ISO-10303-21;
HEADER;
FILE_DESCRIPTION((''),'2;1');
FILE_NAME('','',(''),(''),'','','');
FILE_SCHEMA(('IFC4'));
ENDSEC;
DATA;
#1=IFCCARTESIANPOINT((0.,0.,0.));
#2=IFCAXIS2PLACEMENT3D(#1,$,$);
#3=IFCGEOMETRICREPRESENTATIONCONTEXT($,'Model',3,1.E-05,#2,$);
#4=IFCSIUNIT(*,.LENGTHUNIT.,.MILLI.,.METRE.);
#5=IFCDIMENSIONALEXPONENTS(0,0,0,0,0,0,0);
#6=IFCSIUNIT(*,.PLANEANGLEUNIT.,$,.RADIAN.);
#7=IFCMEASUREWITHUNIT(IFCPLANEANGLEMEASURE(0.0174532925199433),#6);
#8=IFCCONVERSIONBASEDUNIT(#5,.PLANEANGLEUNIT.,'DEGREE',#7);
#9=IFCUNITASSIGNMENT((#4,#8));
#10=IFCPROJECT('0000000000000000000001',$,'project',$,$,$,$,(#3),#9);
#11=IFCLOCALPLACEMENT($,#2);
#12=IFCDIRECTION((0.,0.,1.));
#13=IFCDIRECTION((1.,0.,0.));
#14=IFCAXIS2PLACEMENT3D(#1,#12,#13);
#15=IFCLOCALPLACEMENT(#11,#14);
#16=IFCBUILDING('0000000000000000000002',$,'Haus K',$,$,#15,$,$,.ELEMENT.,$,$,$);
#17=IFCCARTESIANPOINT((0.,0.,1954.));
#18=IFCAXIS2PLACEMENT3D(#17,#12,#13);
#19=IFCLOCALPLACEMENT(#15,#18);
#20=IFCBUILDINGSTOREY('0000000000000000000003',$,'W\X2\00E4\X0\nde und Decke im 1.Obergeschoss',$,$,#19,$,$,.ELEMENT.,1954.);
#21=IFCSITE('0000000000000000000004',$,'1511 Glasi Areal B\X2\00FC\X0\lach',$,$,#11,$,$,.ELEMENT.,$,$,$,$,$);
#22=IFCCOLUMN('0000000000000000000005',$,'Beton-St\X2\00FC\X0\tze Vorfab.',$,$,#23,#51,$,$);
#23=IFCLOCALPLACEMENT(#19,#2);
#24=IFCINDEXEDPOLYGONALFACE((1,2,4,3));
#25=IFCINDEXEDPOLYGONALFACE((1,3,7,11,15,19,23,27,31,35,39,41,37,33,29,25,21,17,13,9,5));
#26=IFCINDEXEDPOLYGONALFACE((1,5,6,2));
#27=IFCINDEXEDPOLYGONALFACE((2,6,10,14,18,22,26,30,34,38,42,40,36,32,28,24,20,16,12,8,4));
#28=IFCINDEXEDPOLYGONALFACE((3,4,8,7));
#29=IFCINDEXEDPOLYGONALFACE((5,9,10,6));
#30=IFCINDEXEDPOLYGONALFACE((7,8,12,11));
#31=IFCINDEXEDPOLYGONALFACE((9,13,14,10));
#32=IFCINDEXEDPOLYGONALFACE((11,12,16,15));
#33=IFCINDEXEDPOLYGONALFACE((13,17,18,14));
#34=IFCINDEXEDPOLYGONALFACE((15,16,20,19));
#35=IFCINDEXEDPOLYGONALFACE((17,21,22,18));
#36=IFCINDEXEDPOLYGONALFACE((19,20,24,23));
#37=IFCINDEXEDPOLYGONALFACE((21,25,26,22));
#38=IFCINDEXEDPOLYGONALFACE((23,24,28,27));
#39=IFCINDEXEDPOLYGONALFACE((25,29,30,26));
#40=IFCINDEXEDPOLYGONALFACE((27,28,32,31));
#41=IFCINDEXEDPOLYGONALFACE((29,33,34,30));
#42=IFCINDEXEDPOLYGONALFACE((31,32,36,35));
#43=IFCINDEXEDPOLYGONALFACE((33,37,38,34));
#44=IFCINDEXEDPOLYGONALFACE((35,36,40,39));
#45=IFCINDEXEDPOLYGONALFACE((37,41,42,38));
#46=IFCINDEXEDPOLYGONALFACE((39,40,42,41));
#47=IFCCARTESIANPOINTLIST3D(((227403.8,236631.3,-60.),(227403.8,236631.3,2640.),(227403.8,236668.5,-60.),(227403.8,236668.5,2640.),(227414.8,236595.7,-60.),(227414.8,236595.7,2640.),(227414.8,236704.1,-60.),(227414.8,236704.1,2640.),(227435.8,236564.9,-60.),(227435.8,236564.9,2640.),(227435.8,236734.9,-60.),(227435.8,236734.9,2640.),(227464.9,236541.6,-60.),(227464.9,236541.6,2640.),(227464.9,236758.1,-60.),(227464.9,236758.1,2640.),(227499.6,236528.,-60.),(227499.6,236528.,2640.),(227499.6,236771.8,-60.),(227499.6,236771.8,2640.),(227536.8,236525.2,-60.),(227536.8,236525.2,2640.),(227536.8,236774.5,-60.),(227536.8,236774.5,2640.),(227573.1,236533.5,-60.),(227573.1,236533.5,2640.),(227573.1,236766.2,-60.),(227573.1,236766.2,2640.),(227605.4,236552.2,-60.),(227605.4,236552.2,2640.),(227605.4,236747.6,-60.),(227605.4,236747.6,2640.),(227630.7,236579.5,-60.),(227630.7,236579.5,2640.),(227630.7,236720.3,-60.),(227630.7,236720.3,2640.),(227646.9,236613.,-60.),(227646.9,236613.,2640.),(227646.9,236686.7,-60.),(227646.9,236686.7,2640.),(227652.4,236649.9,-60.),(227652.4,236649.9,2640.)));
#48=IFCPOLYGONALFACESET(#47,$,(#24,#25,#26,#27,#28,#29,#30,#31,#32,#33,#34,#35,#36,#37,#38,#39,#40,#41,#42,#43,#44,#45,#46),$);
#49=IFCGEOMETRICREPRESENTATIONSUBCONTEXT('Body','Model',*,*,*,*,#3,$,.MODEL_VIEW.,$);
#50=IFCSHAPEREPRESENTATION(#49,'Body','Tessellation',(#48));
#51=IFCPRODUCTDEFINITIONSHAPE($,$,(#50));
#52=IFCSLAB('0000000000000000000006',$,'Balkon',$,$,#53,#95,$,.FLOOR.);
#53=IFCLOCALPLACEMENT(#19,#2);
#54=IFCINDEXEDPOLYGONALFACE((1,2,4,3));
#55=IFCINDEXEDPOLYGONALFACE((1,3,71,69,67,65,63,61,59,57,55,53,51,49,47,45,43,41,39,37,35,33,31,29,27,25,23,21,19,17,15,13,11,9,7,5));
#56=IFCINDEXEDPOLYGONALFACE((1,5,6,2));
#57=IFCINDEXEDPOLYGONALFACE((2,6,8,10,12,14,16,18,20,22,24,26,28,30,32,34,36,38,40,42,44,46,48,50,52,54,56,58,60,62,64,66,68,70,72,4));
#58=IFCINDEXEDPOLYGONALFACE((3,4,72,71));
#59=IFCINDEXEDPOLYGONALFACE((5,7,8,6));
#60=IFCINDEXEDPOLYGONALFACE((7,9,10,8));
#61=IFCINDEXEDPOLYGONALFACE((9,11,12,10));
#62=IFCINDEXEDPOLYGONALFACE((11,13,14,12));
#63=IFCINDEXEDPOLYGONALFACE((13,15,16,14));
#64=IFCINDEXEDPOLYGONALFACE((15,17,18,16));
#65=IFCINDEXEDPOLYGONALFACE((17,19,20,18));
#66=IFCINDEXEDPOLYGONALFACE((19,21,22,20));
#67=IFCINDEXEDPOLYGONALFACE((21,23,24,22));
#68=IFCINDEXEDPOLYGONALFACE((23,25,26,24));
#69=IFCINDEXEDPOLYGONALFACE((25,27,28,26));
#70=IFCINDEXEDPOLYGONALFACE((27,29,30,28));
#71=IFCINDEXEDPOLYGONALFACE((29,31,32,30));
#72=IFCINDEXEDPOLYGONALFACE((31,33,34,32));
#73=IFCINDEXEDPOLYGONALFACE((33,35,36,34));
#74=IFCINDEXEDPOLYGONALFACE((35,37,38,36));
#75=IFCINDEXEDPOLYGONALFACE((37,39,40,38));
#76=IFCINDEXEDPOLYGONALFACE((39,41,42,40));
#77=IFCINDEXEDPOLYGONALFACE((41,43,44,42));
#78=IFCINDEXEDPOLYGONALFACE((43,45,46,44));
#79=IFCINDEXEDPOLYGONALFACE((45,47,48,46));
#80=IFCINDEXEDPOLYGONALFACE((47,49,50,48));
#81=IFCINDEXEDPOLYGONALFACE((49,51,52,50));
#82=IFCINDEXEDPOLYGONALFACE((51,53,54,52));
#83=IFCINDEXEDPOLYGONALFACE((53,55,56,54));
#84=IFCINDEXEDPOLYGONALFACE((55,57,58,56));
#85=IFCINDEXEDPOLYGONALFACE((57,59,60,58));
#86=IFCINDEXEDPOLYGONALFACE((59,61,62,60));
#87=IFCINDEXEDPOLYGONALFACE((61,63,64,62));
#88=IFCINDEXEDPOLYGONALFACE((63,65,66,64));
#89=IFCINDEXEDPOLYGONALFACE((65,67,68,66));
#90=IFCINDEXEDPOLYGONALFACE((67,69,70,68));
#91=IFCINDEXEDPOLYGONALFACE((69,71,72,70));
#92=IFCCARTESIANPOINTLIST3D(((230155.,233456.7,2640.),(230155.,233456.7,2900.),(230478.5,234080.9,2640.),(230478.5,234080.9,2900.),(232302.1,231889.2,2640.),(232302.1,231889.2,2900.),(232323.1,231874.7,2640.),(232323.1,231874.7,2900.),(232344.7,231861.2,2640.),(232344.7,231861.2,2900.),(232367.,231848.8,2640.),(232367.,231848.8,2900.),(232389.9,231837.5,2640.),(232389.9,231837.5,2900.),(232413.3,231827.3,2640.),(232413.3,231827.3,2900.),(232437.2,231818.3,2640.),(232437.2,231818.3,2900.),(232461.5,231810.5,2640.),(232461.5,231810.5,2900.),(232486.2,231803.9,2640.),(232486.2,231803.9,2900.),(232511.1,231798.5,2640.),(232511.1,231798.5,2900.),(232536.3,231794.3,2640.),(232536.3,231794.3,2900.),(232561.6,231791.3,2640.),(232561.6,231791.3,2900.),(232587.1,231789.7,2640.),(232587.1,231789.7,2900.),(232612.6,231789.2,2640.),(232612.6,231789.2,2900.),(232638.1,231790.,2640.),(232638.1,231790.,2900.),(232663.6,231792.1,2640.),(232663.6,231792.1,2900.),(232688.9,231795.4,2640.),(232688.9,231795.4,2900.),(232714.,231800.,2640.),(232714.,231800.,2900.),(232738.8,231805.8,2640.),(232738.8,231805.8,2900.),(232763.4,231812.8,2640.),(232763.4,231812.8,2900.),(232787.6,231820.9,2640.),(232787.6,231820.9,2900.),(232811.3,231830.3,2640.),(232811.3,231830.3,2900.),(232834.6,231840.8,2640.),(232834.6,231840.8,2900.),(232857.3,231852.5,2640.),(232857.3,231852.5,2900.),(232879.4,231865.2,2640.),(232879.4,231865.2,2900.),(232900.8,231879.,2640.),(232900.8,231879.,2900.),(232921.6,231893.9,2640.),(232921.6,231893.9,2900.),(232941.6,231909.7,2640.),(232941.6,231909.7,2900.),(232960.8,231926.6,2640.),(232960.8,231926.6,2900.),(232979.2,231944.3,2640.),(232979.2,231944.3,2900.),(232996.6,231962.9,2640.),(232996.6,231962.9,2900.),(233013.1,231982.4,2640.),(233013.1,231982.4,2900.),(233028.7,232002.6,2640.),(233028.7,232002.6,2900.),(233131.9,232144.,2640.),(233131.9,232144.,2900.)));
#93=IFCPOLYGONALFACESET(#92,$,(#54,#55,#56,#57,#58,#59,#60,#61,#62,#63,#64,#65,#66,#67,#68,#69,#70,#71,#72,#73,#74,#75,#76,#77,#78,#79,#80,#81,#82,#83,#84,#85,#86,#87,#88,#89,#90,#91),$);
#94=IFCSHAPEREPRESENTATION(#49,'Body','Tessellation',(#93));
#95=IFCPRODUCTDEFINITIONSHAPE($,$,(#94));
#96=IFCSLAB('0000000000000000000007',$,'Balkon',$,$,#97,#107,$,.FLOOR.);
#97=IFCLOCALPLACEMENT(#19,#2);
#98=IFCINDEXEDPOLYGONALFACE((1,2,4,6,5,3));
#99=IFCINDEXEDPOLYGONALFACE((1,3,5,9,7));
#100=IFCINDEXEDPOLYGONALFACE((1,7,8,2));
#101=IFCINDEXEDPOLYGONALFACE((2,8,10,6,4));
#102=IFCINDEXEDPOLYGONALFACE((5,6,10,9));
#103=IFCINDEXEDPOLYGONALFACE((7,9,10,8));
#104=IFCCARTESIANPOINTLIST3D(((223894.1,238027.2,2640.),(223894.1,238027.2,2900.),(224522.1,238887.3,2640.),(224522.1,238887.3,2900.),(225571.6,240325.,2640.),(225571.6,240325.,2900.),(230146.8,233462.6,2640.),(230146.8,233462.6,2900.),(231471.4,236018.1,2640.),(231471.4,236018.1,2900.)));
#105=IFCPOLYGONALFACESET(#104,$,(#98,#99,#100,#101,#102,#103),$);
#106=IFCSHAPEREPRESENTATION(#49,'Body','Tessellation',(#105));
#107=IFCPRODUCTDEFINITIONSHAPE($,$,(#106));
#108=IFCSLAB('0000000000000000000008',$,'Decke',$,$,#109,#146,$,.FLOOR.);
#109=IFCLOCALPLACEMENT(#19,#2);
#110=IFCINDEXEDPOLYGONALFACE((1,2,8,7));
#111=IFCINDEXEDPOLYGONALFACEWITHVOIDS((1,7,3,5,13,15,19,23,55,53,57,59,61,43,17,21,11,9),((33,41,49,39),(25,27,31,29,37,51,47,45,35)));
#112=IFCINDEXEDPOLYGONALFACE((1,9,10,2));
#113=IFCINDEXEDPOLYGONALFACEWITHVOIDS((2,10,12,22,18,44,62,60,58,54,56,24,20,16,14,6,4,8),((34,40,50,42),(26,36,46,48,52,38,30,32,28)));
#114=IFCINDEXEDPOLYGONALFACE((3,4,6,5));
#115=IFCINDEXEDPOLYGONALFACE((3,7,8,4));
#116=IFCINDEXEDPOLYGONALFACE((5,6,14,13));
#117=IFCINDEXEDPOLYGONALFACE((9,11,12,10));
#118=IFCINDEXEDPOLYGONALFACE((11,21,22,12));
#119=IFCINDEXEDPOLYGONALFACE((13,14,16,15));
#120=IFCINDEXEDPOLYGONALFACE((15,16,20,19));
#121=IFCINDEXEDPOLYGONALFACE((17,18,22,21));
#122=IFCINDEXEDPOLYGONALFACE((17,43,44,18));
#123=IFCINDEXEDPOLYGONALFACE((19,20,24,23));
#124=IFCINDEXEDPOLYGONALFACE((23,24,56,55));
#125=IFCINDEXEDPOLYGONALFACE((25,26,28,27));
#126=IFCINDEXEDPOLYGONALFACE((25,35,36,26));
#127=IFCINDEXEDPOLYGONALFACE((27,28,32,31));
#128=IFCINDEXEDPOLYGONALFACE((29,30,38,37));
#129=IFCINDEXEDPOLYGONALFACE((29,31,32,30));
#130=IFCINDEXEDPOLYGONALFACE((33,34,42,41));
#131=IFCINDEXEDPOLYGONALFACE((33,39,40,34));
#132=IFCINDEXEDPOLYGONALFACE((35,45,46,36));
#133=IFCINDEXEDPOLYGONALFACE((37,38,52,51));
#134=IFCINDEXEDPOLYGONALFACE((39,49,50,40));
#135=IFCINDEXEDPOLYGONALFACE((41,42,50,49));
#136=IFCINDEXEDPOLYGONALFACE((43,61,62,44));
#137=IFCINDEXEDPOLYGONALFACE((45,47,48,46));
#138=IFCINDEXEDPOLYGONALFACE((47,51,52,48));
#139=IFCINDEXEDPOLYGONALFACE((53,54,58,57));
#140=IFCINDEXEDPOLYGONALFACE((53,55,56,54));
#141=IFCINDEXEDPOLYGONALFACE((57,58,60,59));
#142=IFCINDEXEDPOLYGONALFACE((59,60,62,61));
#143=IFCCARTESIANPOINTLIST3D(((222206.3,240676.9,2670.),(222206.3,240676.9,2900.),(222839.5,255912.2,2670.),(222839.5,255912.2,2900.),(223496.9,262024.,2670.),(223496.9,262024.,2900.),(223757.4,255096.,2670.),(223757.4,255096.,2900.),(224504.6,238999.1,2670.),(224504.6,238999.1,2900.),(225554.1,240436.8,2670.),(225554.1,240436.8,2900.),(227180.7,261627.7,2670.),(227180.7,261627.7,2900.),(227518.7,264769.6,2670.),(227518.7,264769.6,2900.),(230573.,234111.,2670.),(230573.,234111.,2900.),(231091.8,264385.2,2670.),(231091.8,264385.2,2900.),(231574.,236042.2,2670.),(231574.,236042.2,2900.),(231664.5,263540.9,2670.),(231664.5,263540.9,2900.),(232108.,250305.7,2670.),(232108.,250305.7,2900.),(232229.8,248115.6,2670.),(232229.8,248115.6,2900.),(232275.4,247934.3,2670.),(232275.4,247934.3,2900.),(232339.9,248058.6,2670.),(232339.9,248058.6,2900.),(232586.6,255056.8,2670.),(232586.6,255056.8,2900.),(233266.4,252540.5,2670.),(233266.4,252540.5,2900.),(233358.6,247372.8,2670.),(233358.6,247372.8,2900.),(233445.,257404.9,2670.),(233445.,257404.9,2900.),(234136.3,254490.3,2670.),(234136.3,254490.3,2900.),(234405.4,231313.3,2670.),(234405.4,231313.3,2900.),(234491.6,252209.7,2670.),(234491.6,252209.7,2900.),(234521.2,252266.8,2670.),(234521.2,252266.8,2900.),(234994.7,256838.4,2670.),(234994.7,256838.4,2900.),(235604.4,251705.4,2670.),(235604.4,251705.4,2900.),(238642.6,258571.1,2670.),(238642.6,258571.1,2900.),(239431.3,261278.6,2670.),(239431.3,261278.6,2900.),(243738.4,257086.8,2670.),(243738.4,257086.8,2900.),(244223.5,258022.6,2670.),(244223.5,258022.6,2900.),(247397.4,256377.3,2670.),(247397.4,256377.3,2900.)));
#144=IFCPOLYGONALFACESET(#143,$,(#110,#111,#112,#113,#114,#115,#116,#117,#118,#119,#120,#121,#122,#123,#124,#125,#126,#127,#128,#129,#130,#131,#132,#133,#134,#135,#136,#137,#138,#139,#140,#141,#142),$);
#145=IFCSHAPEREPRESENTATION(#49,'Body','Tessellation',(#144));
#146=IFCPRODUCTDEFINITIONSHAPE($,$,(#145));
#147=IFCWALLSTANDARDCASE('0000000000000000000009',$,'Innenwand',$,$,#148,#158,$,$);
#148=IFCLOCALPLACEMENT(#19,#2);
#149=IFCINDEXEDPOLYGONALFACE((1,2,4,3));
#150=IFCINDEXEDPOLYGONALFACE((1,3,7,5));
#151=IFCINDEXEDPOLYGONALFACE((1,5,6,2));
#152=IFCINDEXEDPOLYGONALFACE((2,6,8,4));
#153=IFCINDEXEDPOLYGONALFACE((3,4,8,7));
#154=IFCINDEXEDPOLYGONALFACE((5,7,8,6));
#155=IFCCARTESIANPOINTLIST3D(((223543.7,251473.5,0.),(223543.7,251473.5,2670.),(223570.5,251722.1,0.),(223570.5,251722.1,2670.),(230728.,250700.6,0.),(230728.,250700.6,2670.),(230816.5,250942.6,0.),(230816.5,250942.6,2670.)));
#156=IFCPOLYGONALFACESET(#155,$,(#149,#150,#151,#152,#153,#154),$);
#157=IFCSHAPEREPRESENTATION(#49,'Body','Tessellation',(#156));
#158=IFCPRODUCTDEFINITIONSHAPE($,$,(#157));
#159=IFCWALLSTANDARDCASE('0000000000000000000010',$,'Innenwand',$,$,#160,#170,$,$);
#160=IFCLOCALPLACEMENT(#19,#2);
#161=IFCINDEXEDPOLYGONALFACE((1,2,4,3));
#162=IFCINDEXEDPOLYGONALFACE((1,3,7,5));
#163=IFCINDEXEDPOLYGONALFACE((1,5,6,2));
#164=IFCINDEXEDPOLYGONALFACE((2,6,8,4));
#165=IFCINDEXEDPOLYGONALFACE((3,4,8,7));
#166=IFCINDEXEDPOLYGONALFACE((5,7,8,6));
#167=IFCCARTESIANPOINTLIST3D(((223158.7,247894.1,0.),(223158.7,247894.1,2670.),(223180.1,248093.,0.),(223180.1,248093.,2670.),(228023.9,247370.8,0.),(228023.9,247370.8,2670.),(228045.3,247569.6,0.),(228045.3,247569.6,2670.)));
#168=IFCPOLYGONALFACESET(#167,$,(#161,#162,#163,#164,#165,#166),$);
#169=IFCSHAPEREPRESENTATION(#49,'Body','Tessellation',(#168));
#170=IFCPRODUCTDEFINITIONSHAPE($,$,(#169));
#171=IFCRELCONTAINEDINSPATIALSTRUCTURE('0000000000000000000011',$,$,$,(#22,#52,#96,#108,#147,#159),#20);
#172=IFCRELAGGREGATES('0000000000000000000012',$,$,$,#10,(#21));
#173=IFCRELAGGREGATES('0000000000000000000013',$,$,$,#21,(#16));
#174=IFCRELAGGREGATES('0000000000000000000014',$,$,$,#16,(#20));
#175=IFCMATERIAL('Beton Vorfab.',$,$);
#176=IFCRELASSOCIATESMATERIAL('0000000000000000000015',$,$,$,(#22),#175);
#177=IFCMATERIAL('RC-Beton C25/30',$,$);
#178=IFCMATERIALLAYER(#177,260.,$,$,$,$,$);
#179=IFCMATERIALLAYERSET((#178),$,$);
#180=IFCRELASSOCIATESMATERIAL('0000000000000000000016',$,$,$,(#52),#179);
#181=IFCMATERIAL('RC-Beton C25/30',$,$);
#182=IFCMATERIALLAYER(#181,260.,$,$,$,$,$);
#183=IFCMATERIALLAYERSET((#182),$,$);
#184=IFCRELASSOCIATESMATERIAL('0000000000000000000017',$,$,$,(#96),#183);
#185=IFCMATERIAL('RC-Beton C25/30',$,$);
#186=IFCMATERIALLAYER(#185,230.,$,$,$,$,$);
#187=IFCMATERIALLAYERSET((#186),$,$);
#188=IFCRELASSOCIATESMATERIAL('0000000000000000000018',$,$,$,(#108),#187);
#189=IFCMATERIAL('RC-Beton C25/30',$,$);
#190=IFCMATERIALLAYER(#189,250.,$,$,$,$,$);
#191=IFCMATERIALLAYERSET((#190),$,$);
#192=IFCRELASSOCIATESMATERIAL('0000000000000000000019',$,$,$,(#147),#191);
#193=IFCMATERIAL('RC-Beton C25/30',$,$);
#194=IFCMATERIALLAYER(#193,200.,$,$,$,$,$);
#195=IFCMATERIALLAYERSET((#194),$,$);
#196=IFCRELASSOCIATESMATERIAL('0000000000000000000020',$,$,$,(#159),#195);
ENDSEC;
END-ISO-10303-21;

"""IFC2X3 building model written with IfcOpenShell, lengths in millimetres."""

from ifc_helpers import new_model, entity, si_unit, converted_unit, frame, frame_2d, origin, origin_with_axes, place, context, subcontext, project, spatial, polyline, rectangle, circle, outline, extrude, material, layer, layer_set, layer_usage, element, save


model = new_model("IFC2X3")

# Units and contexts
model_context = context("Model", 3, precision=1e-05, world=origin())
body_context = subcontext(model_context, "Body", "Model", "MODEL_VIEW")
ifc_project = project(units=[si_unit("LENGTHUNIT", "METRE", prefix="MILLI"), converted_unit("PLANEANGLEUNIT", "DEGREE", entity("IfcPlaneAngleMeasure", 0.0174532925199433), si_unit("PLANEANGLEUNIT", "RADIAN"), dimensions=[0, 0, 0, 0, 0, 0, 0])], contexts=[model_context])

# Site, building, storey
site_placement = place(None, origin())
site = spatial("IfcSite", under=ifc_project, at=site_placement, Name="1511 Glasi Areal Bülach", CompositionType="ELEMENT")
building_placement = place(site_placement, origin_with_axes())
building = spatial("IfcBuilding", under=site, at=building_placement, Name="Haus K", CompositionType="ELEMENT")
storey_placement = place(building_placement, frame((0.0, 0.0, 1954.0), z_axis=(0.0, 0.0, 1.0), x_axis=(1.0, 0.0, 0.0)))
storey = spatial("IfcBuildingStorey", under=building, at=storey_placement, Name="Wände und Decke im 1.Obergeschoss", CompositionType="ELEMENT", Elevation=1954.0)

# Column
ifc_material_1 = material(Name="Beton Vorfab.")
column_placement = place(storey_placement, frame((227402.9, 236525.4, -60.0), z_axis=(0.0, 0.0, 1.0), x_axis=(1.0, 0.0, 0.0)))
element("IfcColumn", 1, at=column_placement, inside=storey, material=ifc_material_1, Name="Beton-Stütze Vorfab.", context=body_context, shape_type="SweptSolid", body=[
    extrude(circle(Radius=125.0, at=frame_2d((124.5, 124.5), x_axis=(1.0, 0.0))), origin_with_axes(), (0.0, 0.0, 1.0), 2700.0),
])

# Slabs
ifc_material_2 = material(Name="RC-Beton C25/30")
ifc_layer_1 = layer(ifc_material_2, 260.0)
ifc_layer_set_1 = layer_set([ifc_layer_1])
ifc_layer_usage_1 = layer_usage(ifc_layer_set_1, "AXIS3", "POSITIVE", 0.0)
slab_1_placement = place(storey_placement, frame((230155.0, 231789.2, 2640.0), z_axis=(0.0, 0.0, 1.0), x_axis=(1.0, 0.0, 0.0)))
element("IfcSlab", 2, at=slab_1_placement, inside=storey, material=ifc_layer_usage_1, Name="Balkon", PredefinedType="FLOOR", context=body_context, shape_type="SweptSolid", body=[
    extrude(outline(polyline([(2147.1, 100.0), (2168.1, 85.5), (2189.8, 72.0), (2212.1, 59.5), (2235.0, 48.2), (2258.4, 38.1), (2282.2, 29.1), (2306.5, 21.3), (2331.2, 14.6), (2356.1, 9.2), (2381.3, 5.1), (2406.7, 2.1), (2432.1, 0.4), (2457.7, 0.0), (2483.2, 0.8), (2508.6, 2.9), (2533.9, 6.2), (2559.0, 10.8), (2583.9, 16.5), (2608.4, 23.5), (2632.6, 31.7), (2656.3, 41.1), (2679.6, 51.6), (2702.3, 63.2), (2724.4, 76.0), (2745.9, 89.8), (2766.6, 104.7), (2786.6, 120.5), (2805.8, 137.3), (2824.2, 155.1), (2841.7, 173.7), (2858.2, 193.1), (2873.7, 213.4), (2976.9, 354.7), (323.6, 2291.7), (0.0, 1667.4), (2147.1, 100.0)])), origin_with_axes(), (0.0, 0.0, 1.0), 260.0),
])
ifc_material_3 = material(Name="RC-Beton C25/30")
ifc_layer_2 = layer(ifc_material_3, 260.0)
ifc_layer_set_2 = layer_set([ifc_layer_2])
ifc_layer_usage_2 = layer_usage(ifc_layer_set_2, "AXIS3", "POSITIVE", 0.0)
slab_2_placement = place(storey_placement, frame((223894.1, 233462.6, 2640.0), z_axis=(0.0, 0.0, 1.0), x_axis=(1.0, 0.0, 0.0)))
element("IfcSlab", 3, at=slab_2_placement, inside=storey, material=ifc_layer_usage_2, Name="Balkon", PredefinedType="FLOOR", context=body_context, shape_type="SweptSolid", body=[
    extrude(outline(polyline([(0.0, 4564.5), (6252.7, 0.0), (7577.3, 2555.4), (1677.5, 6862.4), (627.9, 5424.7), (0.0, 4564.5)])), origin_with_axes(), (0.0, 0.0, 1.0), 260.0),
])

# Slab, openings
ifc_material_4 = material(Name="RC-Beton C25/30")
ifc_layer_3 = layer(ifc_material_4, 230.0)
ifc_layer_set_3 = layer_set([ifc_layer_3])
ifc_layer_usage_3 = layer_usage(ifc_layer_set_3, "AXIS3", "POSITIVE", 0.0)
slab_3_placement = place(storey_placement, frame((222206.3, 231313.3, 2670.0), z_axis=(0.0, 0.0, 1.0), x_axis=(1.0, 0.0, 0.0)))
slab_3 = element("IfcSlab", 4, at=slab_3_placement, inside=storey, material=ifc_layer_usage_3, Name="Decke", PredefinedType="FLOOR", context=body_context, shape_type="SweptSolid", body=[
    extrude(outline(polyline([(22017.2, 26709.3), (21532.1, 25773.5), (16436.3, 27257.8), (17225.0, 29965.3), (9458.2, 32227.6), (8885.5, 33072.0), (5312.4, 33456.3), (4974.4, 30314.5), (1290.7, 30710.7), (633.2, 24598.9), (1551.1, 23782.8), (0.0, 9363.6), (2298.3, 7685.8), (3347.9, 9123.5), (9367.7, 4728.9), (8366.7, 2797.7), (12199.1, 0.0), (25191.1, 25064.1), (22017.2, 26709.3)])), origin_with_axes(), (0.0, 0.0, 1.0), 230.0),
])
opening_1_placement = place(slab_3_placement, frame((9901.7, 16059.5, 0.0), z_axis=(0.0, 0.0, 1.0), x_axis=(1.0, 0.0, 0.0)))
element("IfcOpeningElement", 5, at=opening_1_placement, cuts=slab_3, ObjectType="Opening", context=body_context, shape_type="SweptSolid", body=[
    extrude(outline(polyline([(2383.7, 4836.9), (1158.4, 5167.7), (0.0, 2932.8), (121.8, 742.8), (231.9, 685.7), (167.5, 561.4), (1250.6, 0.0), (3496.4, 4332.5), (2413.3, 4894.0), (2383.7, 4836.9)])), origin_with_axes(), (0.0, 0.0, 1.0), 230.0),
])
opening_2_placement = place(slab_3_placement, frame((11238.7, 26091.6, 0.0), z_axis=(0.0, 0.0, 1.0), x_axis=(1.0, 0.0, 0.0)))
element("IfcOpeningElement", 6, at=opening_2_placement, cuts=slab_3, ObjectType="Opening", context=body_context, shape_type="SweptSolid", body=[
    extrude(rectangle(XDim=2500.0, YDim=1650.0, at=frame_2d((345.7, -1457.3), x_axis=(-0.343332, -0.939214))), origin_with_axes(), (0.0, 0.0, 1.0), 230.0),
])

# Walls
ifc_material_5 = material(Name="RC-Beton C25/30")
ifc_layer_4 = layer(ifc_material_5, 250.0)
ifc_layer_set_4 = layer_set([ifc_layer_4])
ifc_layer_usage_4 = layer_usage(ifc_layer_set_4, "AXIS2", "POSITIVE", 0.0)
wall_1_placement = place(storey_placement, frame((230816.5, 250942.6, 0.0), z_axis=(0.0, 0.0, 1.0), x_axis=(-0.994264, 0.106958, 0.0)))
element("IfcWallStandardCase", 7, at=wall_1_placement, inside=storey, material=ifc_layer_usage_4, Name="Innenwand", context=body_context, shape_type="SweptSolid", body=[
    extrude(outline(polyline([(0.0, 0.0), (7287.8, 0.0), (7287.8, 250.0), (62.1, 250.0), (0.0, 0.0)])), origin_with_axes(), (0.0, 0.0, 1.0), 2670.0),
])
ifc_material_6 = material(Name="RC-Beton C25/30")
ifc_layer_5 = layer(ifc_material_6, 200.0)
ifc_layer_set_5 = layer_set([ifc_layer_5])
ifc_layer_usage_5 = layer_usage(ifc_layer_set_5, "AXIS2", "POSITIVE", 0.0)
wall_2_placement = place(storey_placement, frame((223158.7, 247894.1, 0.0), z_axis=(0.0, 0.0, 1.0), x_axis=(0.994264, -0.106958, 0.0)))
element("IfcWallStandardCase", 8, at=wall_2_placement, inside=storey, material=ifc_layer_usage_5, Name="Innenwand", context=body_context, shape_type="SweptSolid", body=[
    extrude(rectangle(XDim=4893.3, YDim=200.0, at=frame_2d((2446.7, 100.0), x_axis=(1.0, 0.0))), origin_with_axes(), (0.0, 0.0, 1.0), 2670.0),
])

save(model, "model.ifc")
